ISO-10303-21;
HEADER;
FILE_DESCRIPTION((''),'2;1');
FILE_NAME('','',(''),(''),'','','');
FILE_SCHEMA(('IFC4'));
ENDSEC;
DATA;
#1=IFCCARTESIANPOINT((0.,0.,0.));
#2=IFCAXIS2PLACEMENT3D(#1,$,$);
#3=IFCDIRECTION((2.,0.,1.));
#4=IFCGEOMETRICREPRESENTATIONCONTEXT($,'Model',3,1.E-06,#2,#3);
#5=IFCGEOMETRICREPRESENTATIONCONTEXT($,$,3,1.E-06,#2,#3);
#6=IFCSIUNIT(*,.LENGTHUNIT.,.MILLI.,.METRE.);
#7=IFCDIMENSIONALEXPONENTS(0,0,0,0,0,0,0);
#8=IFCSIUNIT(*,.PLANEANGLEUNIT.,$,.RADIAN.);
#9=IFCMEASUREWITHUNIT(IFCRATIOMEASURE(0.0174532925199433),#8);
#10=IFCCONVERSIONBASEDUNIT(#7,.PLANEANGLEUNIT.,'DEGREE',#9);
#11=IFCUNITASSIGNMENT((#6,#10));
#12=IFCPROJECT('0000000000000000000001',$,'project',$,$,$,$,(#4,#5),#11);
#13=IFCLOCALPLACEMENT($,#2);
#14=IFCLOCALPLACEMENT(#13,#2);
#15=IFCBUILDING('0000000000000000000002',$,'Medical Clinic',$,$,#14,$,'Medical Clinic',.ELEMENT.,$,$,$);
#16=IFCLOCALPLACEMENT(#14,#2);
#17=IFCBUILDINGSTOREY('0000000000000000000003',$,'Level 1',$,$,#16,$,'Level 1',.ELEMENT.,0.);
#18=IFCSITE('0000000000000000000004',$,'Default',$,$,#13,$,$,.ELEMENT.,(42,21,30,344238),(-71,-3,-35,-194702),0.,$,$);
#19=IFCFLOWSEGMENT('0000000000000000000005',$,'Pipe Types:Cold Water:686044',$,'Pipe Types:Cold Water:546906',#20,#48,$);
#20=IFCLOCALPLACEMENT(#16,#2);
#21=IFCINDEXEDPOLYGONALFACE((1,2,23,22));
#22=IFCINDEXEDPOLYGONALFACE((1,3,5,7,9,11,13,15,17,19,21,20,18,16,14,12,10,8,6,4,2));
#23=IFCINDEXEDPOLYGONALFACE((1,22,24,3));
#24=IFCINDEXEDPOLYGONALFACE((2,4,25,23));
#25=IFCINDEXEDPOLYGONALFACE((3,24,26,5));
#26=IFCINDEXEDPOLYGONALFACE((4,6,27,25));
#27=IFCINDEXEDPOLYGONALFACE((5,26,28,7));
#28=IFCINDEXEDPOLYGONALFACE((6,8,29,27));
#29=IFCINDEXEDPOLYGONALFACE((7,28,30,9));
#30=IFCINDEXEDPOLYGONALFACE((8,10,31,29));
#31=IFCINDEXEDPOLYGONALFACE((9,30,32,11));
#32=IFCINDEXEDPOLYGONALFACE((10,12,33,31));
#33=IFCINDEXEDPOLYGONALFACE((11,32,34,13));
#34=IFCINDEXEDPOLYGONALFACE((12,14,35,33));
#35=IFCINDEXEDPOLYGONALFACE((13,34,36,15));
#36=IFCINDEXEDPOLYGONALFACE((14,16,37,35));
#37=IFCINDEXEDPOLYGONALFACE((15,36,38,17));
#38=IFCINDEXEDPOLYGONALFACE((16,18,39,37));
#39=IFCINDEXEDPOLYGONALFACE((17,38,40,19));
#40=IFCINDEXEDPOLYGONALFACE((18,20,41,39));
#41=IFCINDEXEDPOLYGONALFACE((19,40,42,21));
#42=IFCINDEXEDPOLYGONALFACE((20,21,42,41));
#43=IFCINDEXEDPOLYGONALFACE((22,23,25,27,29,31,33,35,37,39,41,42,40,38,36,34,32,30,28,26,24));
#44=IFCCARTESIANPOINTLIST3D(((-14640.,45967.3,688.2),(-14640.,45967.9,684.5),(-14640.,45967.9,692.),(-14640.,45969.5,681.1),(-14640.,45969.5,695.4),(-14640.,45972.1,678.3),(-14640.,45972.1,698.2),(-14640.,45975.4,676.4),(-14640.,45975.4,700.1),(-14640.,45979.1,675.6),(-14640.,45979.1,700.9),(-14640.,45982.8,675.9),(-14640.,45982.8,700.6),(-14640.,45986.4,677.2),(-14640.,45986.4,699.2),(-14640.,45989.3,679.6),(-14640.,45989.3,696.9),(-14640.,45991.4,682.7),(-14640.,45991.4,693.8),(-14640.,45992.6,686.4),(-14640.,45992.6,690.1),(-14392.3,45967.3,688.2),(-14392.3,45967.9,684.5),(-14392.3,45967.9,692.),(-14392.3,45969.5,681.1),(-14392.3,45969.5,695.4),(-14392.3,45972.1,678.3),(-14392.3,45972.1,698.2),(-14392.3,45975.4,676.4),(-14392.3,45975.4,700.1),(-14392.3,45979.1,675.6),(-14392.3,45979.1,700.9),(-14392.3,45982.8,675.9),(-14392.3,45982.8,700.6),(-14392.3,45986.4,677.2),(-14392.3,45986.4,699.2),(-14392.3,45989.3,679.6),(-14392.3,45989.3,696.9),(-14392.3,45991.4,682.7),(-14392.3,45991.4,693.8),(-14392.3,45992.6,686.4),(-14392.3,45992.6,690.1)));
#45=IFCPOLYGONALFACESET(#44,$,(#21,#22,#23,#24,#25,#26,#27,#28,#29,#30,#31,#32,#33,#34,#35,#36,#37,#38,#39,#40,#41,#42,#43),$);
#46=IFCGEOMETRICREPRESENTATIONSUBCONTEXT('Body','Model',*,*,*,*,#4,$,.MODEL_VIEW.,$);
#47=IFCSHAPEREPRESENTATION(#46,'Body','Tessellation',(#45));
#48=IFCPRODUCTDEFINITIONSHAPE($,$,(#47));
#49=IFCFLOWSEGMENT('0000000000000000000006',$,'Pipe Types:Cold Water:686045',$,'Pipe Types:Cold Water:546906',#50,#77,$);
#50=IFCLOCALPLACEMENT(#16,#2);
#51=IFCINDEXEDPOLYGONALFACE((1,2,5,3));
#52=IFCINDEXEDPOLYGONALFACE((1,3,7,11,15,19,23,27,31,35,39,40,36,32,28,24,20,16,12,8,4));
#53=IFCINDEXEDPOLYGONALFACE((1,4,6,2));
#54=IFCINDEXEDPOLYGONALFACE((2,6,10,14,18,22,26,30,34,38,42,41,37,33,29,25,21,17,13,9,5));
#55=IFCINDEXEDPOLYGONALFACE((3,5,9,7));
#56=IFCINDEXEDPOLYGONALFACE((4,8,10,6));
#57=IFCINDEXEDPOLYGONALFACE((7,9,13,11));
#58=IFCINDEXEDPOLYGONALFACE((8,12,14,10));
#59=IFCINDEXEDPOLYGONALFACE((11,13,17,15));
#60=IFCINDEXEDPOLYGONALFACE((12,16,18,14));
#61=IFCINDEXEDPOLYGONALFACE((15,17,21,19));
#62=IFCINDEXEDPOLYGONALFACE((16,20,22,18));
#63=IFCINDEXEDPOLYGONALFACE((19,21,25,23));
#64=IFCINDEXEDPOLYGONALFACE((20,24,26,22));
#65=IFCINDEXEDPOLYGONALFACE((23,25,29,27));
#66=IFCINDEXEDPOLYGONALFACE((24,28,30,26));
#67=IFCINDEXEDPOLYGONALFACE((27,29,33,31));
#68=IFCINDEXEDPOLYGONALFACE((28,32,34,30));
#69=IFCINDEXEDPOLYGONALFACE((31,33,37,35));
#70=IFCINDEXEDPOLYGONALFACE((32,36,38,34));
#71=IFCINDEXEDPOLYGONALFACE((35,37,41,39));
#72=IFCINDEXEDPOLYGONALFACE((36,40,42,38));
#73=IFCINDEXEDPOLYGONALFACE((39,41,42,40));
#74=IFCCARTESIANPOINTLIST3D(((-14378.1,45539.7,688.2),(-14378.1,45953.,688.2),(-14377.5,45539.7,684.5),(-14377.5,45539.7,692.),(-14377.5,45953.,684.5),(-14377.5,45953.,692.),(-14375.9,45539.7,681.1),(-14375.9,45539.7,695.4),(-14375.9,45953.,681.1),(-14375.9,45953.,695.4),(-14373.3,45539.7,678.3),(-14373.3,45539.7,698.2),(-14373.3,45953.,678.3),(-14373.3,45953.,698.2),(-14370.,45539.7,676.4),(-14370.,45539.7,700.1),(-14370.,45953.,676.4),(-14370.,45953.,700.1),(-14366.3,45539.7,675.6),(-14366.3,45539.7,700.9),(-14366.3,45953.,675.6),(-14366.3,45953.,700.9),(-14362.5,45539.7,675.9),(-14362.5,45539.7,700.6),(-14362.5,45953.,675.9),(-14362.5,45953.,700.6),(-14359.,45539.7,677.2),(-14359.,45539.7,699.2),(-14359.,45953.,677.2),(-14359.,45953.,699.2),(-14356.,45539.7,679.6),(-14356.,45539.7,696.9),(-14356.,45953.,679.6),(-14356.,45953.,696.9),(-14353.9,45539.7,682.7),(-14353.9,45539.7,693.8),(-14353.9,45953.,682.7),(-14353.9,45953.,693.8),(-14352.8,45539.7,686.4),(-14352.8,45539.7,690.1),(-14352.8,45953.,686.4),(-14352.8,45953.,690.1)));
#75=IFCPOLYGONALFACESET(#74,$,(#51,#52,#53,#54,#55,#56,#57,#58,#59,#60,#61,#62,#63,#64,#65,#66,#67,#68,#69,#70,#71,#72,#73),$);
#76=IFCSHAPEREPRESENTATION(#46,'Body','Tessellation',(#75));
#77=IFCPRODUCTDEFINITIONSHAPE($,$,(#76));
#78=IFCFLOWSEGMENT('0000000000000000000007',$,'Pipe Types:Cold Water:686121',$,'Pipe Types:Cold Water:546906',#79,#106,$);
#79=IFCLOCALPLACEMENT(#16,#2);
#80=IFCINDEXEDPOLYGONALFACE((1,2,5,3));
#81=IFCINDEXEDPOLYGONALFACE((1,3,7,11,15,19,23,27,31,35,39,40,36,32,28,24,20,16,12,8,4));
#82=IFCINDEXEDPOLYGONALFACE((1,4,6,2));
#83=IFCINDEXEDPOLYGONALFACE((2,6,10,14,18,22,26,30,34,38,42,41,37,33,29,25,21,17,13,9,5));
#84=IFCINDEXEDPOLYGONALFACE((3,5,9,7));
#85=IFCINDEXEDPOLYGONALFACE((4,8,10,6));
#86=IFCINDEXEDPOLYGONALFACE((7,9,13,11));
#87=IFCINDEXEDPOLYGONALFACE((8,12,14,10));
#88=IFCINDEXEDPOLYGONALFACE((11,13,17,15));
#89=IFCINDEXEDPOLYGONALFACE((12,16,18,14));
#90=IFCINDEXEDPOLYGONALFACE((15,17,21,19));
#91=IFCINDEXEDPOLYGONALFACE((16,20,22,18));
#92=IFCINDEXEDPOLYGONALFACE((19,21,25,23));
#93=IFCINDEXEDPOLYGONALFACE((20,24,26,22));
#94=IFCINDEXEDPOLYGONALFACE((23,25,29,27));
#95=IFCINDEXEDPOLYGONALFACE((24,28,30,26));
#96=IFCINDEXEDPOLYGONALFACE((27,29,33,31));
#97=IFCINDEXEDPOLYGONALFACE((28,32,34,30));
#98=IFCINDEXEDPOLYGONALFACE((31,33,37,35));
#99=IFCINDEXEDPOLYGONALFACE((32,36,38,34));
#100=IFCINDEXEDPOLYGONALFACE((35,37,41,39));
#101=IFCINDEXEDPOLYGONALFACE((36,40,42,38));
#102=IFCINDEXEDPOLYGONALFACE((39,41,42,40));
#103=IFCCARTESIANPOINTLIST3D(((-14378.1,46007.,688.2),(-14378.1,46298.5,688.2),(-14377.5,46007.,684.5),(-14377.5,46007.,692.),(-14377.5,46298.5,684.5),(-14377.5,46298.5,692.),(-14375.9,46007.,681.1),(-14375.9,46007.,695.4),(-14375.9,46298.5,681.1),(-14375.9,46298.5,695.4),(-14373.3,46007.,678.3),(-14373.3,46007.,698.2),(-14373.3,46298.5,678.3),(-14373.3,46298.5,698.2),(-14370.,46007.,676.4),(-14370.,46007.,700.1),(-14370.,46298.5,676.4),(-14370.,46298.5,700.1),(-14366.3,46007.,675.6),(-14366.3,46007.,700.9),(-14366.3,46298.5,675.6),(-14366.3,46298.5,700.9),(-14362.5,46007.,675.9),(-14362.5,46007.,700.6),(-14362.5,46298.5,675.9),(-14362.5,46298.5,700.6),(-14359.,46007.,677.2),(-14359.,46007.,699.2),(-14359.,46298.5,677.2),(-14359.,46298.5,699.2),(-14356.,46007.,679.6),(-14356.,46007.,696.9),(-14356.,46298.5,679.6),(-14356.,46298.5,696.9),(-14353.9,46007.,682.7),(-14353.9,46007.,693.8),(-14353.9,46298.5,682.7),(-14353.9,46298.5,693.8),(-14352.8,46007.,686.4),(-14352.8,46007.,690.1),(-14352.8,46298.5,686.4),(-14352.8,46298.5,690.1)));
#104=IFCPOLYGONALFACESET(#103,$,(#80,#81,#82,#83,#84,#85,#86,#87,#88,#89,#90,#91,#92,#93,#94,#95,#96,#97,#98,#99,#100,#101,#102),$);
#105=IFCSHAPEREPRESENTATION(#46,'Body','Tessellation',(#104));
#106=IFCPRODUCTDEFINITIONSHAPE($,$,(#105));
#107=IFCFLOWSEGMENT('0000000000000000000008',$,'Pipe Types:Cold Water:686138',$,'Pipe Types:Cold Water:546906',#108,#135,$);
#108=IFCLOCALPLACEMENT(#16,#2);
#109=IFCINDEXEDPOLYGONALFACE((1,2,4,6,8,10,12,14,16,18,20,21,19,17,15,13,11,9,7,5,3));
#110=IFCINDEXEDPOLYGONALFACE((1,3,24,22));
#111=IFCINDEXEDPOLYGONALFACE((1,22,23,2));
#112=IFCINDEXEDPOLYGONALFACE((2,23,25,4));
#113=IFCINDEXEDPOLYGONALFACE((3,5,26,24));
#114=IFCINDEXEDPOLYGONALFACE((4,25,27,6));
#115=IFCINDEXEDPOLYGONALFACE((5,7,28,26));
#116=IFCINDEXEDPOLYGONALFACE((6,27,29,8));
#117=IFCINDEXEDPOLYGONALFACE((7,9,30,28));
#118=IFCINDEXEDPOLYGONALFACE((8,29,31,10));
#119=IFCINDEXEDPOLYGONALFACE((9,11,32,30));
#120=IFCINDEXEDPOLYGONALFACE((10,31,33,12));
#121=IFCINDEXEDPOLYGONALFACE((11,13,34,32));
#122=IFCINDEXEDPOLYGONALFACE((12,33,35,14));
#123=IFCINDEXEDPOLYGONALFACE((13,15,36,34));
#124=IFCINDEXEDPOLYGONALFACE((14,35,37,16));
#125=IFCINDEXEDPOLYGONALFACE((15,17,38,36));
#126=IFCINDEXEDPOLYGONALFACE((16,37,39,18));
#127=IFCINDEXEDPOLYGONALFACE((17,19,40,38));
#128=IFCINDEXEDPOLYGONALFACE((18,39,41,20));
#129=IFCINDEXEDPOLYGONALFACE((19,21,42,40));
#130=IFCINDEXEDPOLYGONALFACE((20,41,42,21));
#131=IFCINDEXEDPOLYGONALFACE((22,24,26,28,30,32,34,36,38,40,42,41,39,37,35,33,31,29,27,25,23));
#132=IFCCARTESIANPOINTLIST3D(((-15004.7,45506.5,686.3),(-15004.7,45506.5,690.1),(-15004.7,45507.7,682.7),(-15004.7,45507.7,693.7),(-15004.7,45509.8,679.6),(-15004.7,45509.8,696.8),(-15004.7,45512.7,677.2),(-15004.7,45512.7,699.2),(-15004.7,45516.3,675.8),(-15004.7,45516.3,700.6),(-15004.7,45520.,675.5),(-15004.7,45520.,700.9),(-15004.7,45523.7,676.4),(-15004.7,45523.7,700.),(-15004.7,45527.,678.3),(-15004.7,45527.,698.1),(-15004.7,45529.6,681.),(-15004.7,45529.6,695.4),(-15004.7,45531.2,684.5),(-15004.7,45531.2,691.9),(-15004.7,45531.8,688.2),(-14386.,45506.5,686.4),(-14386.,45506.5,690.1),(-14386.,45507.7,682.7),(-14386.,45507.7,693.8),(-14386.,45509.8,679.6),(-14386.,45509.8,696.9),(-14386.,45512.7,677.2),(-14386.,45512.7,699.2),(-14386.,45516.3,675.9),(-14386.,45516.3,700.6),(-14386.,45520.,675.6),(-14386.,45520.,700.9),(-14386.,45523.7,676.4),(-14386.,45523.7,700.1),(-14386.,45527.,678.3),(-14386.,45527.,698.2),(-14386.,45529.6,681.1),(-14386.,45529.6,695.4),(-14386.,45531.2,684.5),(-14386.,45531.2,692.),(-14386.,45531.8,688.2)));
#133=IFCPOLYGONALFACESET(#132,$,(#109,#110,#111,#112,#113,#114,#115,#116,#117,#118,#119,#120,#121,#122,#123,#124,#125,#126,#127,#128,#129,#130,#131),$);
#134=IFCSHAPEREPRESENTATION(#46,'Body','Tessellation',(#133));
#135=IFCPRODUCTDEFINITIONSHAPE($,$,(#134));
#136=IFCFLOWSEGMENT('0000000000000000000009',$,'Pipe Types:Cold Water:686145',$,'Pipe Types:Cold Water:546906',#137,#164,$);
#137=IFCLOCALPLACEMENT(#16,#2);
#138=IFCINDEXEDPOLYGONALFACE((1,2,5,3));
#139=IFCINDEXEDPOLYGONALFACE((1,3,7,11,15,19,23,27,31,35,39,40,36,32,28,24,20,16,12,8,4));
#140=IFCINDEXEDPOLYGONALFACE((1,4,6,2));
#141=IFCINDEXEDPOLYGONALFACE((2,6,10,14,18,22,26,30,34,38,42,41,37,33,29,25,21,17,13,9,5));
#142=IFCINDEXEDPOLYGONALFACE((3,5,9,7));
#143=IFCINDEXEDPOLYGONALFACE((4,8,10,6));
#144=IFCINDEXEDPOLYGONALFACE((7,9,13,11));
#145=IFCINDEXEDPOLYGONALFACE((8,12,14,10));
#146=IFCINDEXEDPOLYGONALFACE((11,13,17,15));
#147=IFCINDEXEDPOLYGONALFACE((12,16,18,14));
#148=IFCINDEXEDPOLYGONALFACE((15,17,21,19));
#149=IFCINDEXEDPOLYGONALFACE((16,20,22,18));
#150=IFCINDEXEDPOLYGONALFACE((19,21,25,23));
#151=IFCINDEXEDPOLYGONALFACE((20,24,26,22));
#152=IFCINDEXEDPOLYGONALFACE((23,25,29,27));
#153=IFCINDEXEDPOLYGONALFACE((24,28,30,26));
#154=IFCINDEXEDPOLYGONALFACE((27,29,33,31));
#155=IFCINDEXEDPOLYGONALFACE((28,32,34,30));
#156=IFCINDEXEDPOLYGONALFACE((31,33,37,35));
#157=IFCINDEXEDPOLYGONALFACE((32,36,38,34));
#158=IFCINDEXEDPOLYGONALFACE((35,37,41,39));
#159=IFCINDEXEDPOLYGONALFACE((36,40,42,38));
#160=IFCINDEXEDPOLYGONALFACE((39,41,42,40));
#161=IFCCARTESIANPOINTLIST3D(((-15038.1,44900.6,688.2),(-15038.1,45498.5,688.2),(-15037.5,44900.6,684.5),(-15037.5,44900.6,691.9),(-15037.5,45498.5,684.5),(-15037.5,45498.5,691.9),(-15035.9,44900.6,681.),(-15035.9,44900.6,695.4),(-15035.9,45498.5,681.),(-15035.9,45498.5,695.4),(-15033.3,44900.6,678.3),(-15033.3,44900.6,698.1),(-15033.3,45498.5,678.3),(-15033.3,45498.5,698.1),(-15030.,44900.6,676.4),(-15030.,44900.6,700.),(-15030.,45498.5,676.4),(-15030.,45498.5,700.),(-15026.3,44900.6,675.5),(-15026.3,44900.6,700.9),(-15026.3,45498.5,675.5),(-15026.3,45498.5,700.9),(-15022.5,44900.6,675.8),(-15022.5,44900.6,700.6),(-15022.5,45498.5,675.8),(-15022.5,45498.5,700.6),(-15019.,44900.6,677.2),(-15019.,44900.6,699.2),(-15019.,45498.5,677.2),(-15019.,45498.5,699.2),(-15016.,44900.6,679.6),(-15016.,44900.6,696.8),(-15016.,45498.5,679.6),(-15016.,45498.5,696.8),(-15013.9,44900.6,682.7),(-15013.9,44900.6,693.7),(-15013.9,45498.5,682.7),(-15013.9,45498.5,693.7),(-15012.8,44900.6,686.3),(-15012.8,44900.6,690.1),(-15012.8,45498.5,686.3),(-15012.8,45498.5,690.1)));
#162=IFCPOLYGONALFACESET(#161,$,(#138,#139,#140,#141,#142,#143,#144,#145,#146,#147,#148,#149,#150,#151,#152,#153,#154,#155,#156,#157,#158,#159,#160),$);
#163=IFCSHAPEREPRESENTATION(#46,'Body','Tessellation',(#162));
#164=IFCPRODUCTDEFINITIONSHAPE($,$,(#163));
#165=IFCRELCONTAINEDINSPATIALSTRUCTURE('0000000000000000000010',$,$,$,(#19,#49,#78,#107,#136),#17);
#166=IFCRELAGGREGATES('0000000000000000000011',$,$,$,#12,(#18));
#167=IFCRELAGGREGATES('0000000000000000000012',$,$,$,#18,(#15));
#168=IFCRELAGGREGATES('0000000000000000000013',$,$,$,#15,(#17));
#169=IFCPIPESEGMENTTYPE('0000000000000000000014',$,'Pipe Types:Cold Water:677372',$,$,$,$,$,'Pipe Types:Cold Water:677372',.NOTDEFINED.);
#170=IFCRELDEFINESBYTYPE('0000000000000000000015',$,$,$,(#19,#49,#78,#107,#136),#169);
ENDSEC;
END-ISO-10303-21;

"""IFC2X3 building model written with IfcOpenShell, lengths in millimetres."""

from ifc_helpers import new_model, entity, si_unit, converted_unit, direction, frame, frame_2d, origin, origin_2d_with_axis, place, context, subcontext, project, spatial, circle, extrude, type_object, element, save


model = new_model("IFC2X3")

# Units and contexts
model_context = context("Model", 3, precision=1e-06, world=origin(), true_north=direction((2.0, 0.0, 1.0)))
context_of_model = context(None, 3, precision=1e-06, world=origin(), true_north=direction((2.0, 0.0, 1.0)))
body_context = subcontext(model_context, "Body", "Model", "MODEL_VIEW")
ifc_project = project(units=[si_unit("LENGTHUNIT", "METRE", prefix="MILLI"), converted_unit("PLANEANGLEUNIT", "DEGREE", entity("IfcRatioMeasure", 0.0174532925199433), si_unit("PLANEANGLEUNIT", "RADIAN"), dimensions=[0, 0, 0, 0, 0, 0, 0])], contexts=[model_context, context_of_model])

# Site, building, storey
site_placement = place(None, origin())
site = spatial("IfcSite", under=ifc_project, at=site_placement, Name="Default", CompositionType="ELEMENT", RefLatitude=(42, 21, 30, 344238), RefLongitude=(-71, -3, -35, -194702), RefElevation=0.0)
building_placement = place(site_placement, origin())
building = spatial("IfcBuilding", under=site, at=building_placement, Name="Medical Clinic", LongName="Medical Clinic", CompositionType="ELEMENT")
storey_placement = place(building_placement, origin())
storey = spatial("IfcBuildingStorey", under=building, at=storey_placement, Name="Level 1", LongName="Level 1", CompositionType="ELEMENT", Elevation=0.0)

# Flow segments
pipe_segment_type = type_object("IfcPipeSegmentType", Name="Pipe Types:Cold Water:677372", ElementType="Pipe Types:Cold Water:677372", PredefinedType="NOTDEFINED")
flow_segment_1_placement = place(storey_placement, origin())
element("IfcFlowSegment", 1, at=flow_segment_1_placement, inside=storey, type_object=pipe_segment_type, Name="Pipe Types:Cold Water:686044", ObjectType="Pipe Types:Cold Water:546906", context=body_context, shape_type="SweptSolid", body=[
    extrude(circle(Radius=12.7, at=frame_2d((0.0, 0.0), x_axis=(1.0, 0.0))), frame((-14640.0, 45980.0, 688.2), z_axis=(1.0, 0.0, 0.0), x_axis=(0.0, -1.0, 0.0)), (0.0, 0.0, 1.0), 247.7),
])
flow_segment_2_placement = place(storey_placement, origin())
element("IfcFlowSegment", 2, at=flow_segment_2_placement, inside=storey, type_object=pipe_segment_type, Name="Pipe Types:Cold Water:686045", ObjectType="Pipe Types:Cold Water:546906", context=body_context, shape_type="SweptSolid", body=[
    extrude(circle(Radius=12.7, at=frame_2d((0.0, 0.0), x_axis=(1.0, 0.0))), frame((-14365.4, 45539.7, 688.2), z_axis=(0.0, 1.0, 0.0), x_axis=(-1.0, 0.0, 0.0)), (0.0, 0.0, 1.0), 413.3),
])
flow_segment_3_placement = place(storey_placement, origin())
element("IfcFlowSegment", 3, at=flow_segment_3_placement, inside=storey, type_object=pipe_segment_type, Name="Pipe Types:Cold Water:686121", ObjectType="Pipe Types:Cold Water:546906", context=body_context, shape_type="SweptSolid", body=[
    extrude(circle(Radius=12.7, at=frame_2d((0.0, 0.0), x_axis=(1.0, 0.0))), frame((-14365.4, 46007.0, 688.2), z_axis=(0.0, 1.0, 0.0), x_axis=(-1.0, 0.0, 0.0)), (0.0, 0.0, 1.0), 291.5),
])
flow_segment_4_placement = place(storey_placement, origin())
element("IfcFlowSegment", 4, at=flow_segment_4_placement, inside=storey, type_object=pipe_segment_type, Name="Pipe Types:Cold Water:686138", ObjectType="Pipe Types:Cold Water:546906", context=body_context, shape_type="SweptSolid", body=[
    extrude(circle(Radius=12.7, at=origin_2d_with_axis()), frame((-15004.7, 45519.1, 688.2), z_axis=(1.0, 0.0, 0.000068), x_axis=(0.0, 1.0, 0.0)), (0.0, 0.0, 1.0), 618.7),
])
flow_segment_5_placement = place(storey_placement, origin())
element("IfcFlowSegment", 5, at=flow_segment_5_placement, inside=storey, type_object=pipe_segment_type, Name="Pipe Types:Cold Water:686145", ObjectType="Pipe Types:Cold Water:546906", context=body_context, shape_type="SweptSolid", body=[
    extrude(circle(Radius=12.7, at=frame_2d((0.0, 0.0), x_axis=(1.0, 0.0))), frame((-15025.4, 44900.6, 688.2), z_axis=(0.0, 1.0, 0.0), x_axis=(-1.0, 0.0, 0.0)), (0.0, 0.0, 1.0), 597.8),
])

save(model, "model.ifc")
